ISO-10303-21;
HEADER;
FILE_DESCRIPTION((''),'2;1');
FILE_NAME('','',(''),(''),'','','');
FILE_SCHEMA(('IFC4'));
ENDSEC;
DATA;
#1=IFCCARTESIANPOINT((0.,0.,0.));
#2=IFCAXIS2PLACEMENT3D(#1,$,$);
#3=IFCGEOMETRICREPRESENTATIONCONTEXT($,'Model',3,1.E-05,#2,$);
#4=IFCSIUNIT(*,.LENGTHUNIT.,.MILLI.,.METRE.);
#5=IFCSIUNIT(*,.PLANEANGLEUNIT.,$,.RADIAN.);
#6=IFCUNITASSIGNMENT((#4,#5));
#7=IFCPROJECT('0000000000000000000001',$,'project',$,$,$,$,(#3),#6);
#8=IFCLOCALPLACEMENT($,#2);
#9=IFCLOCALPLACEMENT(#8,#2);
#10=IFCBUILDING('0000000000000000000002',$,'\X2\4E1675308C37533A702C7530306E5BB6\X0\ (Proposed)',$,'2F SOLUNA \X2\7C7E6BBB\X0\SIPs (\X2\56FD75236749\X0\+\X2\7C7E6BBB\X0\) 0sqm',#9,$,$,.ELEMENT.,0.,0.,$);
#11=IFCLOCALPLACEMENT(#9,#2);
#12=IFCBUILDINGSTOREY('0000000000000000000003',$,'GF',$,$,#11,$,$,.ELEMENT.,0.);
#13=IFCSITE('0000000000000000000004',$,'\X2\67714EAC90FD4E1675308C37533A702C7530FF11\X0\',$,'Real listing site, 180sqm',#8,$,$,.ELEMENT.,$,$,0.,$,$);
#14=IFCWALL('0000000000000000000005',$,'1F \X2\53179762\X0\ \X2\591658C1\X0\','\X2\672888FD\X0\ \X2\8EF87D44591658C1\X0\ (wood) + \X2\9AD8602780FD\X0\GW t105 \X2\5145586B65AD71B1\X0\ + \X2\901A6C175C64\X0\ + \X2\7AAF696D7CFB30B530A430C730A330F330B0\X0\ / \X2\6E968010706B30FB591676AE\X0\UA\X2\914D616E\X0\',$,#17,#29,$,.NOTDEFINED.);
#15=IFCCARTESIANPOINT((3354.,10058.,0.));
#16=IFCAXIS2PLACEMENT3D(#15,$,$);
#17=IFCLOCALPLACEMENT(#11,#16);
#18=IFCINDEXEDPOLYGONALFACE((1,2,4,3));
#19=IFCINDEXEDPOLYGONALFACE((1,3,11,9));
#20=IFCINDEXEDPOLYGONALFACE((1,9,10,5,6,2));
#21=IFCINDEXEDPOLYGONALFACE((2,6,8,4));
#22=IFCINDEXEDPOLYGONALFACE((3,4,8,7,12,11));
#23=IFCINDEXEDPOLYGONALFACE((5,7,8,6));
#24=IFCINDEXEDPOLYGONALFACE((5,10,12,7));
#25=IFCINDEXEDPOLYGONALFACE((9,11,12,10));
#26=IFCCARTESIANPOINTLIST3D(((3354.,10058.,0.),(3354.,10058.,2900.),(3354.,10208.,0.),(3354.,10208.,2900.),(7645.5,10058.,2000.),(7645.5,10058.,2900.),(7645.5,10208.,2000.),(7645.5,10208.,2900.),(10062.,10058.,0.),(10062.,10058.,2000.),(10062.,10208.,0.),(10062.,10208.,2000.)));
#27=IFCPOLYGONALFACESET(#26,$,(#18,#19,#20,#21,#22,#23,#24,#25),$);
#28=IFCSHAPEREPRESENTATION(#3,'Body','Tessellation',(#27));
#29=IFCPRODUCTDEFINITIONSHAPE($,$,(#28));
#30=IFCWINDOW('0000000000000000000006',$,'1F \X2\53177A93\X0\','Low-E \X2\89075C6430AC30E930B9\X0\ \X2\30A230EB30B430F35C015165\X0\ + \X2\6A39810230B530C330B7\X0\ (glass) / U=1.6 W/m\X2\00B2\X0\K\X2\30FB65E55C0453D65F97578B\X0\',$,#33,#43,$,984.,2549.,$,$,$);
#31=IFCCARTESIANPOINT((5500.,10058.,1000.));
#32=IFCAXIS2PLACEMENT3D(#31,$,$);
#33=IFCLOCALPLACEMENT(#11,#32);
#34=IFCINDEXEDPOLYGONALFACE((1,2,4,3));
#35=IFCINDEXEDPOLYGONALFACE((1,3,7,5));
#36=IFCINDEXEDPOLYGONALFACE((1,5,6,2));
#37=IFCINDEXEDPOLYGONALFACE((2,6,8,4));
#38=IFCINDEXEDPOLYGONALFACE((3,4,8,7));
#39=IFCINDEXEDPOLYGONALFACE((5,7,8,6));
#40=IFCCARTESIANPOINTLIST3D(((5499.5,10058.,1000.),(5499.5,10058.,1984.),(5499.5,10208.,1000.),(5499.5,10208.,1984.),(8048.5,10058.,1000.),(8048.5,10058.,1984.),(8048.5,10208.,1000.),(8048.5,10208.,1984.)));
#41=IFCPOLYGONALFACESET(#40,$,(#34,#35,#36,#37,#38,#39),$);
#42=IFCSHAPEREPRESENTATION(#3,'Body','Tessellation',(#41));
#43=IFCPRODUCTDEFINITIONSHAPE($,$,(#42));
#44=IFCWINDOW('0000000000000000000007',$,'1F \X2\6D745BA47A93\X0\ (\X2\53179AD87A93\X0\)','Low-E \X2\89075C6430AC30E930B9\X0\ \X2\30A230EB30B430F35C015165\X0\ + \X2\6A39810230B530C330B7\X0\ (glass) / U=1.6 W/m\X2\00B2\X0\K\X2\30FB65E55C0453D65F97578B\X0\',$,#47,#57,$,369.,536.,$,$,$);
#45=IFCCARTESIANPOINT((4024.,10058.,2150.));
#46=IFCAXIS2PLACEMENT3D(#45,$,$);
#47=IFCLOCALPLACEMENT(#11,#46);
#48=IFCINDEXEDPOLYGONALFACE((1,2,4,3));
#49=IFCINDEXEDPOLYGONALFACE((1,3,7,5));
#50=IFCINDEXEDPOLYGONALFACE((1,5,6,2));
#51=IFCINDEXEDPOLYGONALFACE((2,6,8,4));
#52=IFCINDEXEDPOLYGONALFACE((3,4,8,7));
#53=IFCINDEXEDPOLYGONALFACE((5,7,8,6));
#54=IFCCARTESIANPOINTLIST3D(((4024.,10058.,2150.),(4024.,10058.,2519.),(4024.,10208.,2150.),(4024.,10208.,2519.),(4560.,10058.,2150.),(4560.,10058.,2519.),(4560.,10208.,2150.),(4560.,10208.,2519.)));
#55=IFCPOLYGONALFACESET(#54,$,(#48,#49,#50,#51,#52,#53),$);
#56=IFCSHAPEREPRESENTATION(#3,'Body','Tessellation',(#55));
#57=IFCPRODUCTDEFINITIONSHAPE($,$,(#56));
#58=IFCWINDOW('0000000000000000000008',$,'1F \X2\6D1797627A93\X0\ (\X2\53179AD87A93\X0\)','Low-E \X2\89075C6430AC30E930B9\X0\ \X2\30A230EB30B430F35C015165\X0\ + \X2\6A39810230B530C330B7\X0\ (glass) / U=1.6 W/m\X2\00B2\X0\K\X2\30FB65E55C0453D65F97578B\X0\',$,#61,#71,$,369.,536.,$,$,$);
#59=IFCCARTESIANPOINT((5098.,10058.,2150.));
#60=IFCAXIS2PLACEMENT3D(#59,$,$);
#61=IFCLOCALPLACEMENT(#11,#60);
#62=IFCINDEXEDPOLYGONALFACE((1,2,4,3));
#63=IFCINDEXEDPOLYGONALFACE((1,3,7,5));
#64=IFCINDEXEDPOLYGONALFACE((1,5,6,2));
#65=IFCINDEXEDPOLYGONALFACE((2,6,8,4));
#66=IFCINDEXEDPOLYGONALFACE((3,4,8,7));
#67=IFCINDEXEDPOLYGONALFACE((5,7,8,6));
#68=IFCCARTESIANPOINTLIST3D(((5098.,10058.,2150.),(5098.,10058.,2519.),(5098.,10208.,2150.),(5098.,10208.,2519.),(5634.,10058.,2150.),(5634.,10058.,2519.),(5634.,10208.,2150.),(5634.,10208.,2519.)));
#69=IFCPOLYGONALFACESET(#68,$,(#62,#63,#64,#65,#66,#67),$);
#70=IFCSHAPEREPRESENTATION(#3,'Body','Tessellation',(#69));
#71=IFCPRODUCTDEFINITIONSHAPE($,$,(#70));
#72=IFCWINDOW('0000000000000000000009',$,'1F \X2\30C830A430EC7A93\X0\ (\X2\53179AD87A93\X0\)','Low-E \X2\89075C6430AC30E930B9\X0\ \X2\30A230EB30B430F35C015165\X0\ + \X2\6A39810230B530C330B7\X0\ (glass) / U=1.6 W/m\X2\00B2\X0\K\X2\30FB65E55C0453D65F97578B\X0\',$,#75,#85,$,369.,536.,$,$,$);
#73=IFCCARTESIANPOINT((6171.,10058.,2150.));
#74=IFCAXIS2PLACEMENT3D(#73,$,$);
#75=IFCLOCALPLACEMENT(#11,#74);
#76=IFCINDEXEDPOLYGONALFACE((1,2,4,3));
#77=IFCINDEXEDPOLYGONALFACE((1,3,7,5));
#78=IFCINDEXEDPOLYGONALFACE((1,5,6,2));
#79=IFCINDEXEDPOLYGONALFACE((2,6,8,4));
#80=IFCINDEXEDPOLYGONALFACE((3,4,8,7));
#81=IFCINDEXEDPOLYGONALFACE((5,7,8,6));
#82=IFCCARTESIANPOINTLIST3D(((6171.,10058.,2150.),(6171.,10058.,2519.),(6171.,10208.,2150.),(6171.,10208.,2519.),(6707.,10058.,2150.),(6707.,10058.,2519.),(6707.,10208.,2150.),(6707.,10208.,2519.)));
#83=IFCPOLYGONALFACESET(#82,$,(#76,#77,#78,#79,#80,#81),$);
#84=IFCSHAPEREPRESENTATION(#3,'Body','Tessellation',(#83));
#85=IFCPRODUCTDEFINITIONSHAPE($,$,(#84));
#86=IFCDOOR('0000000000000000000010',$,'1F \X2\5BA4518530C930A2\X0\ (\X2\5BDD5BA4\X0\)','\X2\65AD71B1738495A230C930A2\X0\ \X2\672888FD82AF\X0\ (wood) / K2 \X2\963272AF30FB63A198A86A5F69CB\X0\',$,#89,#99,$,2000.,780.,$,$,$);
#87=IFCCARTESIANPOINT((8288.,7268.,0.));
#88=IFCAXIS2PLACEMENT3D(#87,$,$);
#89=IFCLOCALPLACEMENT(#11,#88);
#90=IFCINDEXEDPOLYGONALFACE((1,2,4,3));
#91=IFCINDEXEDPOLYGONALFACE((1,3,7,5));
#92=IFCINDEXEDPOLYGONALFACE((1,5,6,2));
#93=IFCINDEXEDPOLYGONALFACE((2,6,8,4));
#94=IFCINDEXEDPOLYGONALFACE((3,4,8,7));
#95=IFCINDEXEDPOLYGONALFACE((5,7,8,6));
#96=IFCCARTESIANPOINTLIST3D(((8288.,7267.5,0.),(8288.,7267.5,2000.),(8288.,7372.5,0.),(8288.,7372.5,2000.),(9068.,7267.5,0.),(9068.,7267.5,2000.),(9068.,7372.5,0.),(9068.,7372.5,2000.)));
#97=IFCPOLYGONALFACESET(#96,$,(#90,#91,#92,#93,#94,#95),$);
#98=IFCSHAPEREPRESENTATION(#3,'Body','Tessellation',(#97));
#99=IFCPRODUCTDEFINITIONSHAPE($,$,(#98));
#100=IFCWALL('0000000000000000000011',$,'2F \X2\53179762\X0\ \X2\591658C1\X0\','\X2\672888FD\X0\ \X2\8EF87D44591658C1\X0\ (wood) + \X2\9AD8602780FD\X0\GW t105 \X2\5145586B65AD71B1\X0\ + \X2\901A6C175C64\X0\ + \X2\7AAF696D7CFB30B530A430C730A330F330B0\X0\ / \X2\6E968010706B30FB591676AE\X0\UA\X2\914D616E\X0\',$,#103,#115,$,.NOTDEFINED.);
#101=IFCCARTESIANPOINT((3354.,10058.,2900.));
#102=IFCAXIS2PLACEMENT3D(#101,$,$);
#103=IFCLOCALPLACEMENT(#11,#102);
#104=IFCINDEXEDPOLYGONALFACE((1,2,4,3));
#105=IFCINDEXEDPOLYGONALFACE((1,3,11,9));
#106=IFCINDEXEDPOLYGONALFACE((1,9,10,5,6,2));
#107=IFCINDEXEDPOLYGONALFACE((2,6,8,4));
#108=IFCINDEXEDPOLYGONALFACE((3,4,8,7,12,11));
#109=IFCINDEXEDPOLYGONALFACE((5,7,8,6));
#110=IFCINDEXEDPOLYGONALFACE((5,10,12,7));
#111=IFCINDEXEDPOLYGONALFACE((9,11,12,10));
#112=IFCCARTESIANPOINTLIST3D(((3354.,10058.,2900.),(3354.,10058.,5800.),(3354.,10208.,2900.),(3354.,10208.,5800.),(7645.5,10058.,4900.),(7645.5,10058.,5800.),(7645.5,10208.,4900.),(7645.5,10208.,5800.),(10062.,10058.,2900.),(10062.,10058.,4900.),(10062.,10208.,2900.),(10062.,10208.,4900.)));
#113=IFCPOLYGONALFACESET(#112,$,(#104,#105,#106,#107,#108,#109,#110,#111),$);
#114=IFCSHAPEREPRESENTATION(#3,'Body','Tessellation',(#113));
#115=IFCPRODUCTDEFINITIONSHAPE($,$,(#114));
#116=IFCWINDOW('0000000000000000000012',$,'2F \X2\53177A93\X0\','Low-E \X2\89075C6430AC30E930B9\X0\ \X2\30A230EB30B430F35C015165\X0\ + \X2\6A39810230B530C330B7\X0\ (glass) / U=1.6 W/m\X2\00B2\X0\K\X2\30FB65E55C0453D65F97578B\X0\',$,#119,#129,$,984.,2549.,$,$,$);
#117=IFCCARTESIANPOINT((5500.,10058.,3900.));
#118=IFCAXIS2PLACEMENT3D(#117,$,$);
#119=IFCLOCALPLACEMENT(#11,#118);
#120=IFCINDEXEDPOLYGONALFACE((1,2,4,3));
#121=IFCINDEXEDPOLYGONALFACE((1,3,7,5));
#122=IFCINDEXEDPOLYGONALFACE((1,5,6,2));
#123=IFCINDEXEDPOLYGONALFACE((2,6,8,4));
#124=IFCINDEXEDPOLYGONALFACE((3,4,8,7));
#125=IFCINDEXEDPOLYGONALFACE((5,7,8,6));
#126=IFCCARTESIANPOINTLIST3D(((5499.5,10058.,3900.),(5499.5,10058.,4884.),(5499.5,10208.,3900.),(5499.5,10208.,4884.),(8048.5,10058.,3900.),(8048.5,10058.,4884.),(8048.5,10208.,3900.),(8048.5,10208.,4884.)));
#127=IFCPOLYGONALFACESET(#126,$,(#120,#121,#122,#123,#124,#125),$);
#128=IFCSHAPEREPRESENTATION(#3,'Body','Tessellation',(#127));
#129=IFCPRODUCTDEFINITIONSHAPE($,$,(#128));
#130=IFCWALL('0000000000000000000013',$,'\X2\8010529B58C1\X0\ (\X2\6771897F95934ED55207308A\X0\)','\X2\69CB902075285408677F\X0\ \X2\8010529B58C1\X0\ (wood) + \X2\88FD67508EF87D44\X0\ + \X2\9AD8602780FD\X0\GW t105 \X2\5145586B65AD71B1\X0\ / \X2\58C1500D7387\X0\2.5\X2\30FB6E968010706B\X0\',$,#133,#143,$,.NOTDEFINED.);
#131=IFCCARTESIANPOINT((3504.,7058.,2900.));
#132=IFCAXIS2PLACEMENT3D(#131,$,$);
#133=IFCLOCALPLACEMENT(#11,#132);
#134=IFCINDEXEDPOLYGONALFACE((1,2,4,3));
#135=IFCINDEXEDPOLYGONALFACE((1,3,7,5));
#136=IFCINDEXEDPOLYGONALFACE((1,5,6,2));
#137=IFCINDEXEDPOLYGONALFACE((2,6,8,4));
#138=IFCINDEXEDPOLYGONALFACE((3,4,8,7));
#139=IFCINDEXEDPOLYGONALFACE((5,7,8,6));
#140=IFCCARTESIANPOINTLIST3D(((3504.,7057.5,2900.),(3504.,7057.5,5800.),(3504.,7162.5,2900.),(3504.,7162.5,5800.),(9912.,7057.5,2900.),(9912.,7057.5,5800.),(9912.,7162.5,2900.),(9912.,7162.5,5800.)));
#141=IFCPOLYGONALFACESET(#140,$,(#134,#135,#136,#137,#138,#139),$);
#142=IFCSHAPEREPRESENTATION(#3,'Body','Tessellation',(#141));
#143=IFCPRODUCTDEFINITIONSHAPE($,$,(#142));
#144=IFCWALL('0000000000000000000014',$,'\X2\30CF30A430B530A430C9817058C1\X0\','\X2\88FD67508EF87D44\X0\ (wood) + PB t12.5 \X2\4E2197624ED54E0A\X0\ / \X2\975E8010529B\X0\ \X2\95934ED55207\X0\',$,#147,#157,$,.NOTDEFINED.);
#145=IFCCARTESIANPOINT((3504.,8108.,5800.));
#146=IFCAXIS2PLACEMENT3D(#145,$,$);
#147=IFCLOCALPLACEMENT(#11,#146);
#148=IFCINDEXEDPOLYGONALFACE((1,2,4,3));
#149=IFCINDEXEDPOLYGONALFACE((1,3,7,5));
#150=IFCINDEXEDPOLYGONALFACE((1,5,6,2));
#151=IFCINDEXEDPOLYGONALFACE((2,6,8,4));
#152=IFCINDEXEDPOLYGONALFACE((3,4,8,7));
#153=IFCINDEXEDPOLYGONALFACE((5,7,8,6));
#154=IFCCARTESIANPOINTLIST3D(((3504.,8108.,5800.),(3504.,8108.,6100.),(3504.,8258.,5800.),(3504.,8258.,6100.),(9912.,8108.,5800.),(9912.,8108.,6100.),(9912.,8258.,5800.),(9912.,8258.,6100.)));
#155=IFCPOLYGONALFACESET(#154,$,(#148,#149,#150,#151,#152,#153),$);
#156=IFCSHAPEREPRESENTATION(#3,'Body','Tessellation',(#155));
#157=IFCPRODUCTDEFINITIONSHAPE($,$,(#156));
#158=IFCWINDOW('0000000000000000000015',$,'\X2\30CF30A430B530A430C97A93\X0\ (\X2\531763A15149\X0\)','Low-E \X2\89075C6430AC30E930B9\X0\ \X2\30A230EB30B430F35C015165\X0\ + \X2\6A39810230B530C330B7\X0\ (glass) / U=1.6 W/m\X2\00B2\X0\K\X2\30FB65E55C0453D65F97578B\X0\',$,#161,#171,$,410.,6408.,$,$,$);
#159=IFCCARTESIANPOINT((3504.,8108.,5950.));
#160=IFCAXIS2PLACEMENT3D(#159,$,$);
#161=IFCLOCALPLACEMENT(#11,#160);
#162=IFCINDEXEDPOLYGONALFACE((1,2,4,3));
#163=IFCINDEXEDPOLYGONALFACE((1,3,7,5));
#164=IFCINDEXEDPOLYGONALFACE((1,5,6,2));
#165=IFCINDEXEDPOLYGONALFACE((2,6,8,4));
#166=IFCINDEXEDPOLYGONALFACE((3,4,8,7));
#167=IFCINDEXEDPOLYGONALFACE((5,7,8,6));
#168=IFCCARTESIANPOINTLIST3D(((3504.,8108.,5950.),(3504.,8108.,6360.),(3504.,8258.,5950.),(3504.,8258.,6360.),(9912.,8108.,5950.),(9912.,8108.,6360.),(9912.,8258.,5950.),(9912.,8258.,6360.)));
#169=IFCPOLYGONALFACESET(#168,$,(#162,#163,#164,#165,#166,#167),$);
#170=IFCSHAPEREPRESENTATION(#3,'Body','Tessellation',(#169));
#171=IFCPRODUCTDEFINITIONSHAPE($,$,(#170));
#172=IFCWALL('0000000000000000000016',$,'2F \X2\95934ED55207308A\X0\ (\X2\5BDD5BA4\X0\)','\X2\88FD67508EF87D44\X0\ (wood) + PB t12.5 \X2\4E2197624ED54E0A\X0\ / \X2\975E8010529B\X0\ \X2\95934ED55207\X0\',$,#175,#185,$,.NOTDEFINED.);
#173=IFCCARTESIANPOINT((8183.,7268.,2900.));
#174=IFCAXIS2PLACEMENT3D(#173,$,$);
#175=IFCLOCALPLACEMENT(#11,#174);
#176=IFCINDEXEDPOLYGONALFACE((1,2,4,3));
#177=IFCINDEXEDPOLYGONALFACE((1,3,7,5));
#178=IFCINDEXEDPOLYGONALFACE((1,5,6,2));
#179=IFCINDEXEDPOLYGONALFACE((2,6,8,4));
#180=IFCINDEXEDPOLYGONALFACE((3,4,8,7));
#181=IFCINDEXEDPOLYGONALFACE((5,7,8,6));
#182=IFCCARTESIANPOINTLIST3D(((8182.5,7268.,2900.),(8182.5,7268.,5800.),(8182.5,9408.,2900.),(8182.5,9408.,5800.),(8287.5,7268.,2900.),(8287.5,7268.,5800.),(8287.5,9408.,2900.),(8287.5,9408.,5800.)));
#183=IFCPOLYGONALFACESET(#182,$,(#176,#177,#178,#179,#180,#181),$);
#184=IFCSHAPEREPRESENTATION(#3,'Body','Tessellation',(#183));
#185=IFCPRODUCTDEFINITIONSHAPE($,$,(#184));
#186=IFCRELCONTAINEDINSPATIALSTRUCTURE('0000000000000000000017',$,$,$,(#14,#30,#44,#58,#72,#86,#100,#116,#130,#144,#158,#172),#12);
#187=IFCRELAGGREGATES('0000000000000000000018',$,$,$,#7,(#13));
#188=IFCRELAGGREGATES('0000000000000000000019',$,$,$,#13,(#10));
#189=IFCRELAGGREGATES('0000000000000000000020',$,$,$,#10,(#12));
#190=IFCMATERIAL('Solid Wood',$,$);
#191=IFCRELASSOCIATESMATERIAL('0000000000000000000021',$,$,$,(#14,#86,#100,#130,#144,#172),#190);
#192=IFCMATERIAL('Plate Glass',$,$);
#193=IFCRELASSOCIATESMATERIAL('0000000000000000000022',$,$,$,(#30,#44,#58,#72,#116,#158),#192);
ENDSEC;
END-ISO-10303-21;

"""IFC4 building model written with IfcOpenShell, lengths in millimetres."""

from ifc_helpers import new_model, si_unit, frame, frame_2d, origin, place, context, project, spatial, rectangle, extrude, material, element, fill, save


model = new_model("IFC4")

# Units and contexts
model_context = context("Model", 3, precision=1e-05, world=origin())
ifc_project = project(units=[si_unit("LENGTHUNIT", "METRE", prefix="MILLI"), si_unit("PLANEANGLEUNIT", "RADIAN")], contexts=[model_context])

# Site, building, storey
site_placement = place(None, origin())
site = spatial("IfcSite", under=ifc_project, at=site_placement, Name="東京都世田谷区瀬田１", ObjectType="Real listing site, 180sqm", CompositionType="ELEMENT", RefElevation=0.0)
building_placement = place(site_placement, origin())
building = spatial("IfcBuilding", under=site, at=building_placement, Name="世田谷区瀬田の家 (Proposed)", ObjectType="2F SOLUNA 籾殻SIPs (国産杉+籾殻) 0sqm", CompositionType="ELEMENT", ElevationOfRefHeight=0.0, ElevationOfTerrain=0.0)
storey_placement = place(building_placement, origin())
storey = spatial("IfcBuildingStorey", under=building, at=storey_placement, Name="GF", CompositionType="ELEMENT", Elevation=0.0)

# Wall, openings, windows
ifc_material_1 = material(Name="Solid Wood")
wall_1_placement = place(storey_placement, frame((3354.0, 10058.0, 0.0)))
wall_1 = element("IfcWall", 1, at=wall_1_placement, inside=storey, material=ifc_material_1, Name="1F 北面 外壁", Description="木製 軸組外壁 (wood) + 高性能GW t105 充填断熱 + 通気層 + 窯業系サイディング / 準耐火・外皮UA配慮", PredefinedType="NOTDEFINED", context=model_context, shape_type="SweptSolid", body=[
    extrude(rectangle(XDim=6708.0, YDim=150.0, at=frame_2d((3354.0, 75.0))), frame((3354.0, 10058.0, 0.0)), (0.0, 0.0, 1.0), 2900.0),
])
opening_1_placement = place(storey_placement, frame((5500.0, 10058.0, 1000.0)))
opening_1 = element("IfcOpeningElement", 2, at=opening_1_placement, cuts=wall_1, PredefinedType="NOTDEFINED", context=model_context, shape_type="SweptSolid", body=[
    extrude(rectangle(XDim=2549.0, YDim=150.0, at=frame_2d((1274.0, 75.0))), frame((5500.0, 10058.0, 1000.0)), (0.0, 0.0, 1.0), 984.0),
])
opening_2_placement = place(storey_placement, frame((4024.0, 10058.0, 2150.0)))
opening_2 = element("IfcOpeningElement", 3, at=opening_2_placement, cuts=wall_1, PredefinedType="NOTDEFINED", context=model_context, shape_type="SweptSolid", body=[
    extrude(rectangle(XDim=536.0, YDim=150.0, at=frame_2d((268.0, 75.0))), frame((4024.0, 10058.0, 2150.0)), (0.0, 0.0, 1.0), 369.0),
])
opening_3_placement = place(storey_placement, frame((5098.0, 10058.0, 2150.0)))
opening_3 = element("IfcOpeningElement", 4, at=opening_3_placement, cuts=wall_1, PredefinedType="NOTDEFINED", context=model_context, shape_type="SweptSolid", body=[
    extrude(rectangle(XDim=536.0, YDim=150.0, at=frame_2d((268.0, 75.0))), frame((5098.0, 10058.0, 2150.0)), (0.0, 0.0, 1.0), 369.0),
])
opening_4_placement = place(storey_placement, frame((6171.0, 10058.0, 2150.0)))
opening_4 = element("IfcOpeningElement", 5, at=opening_4_placement, cuts=wall_1, PredefinedType="NOTDEFINED", context=model_context, shape_type="SweptSolid", body=[
    extrude(rectangle(XDim=536.0, YDim=150.0, at=frame_2d((268.0, 75.0))), frame((6171.0, 10058.0, 2150.0)), (0.0, 0.0, 1.0), 369.0),
])
ifc_material_2 = material(Name="Plate Glass")
window_1_placement = place(storey_placement, frame((5500.0, 10058.0, 1000.0)))
window_1 = element("IfcWindow", 6, at=window_1_placement, inside=storey, material=ifc_material_2, Name="1F 北窓", Description="Low-E 複層ガラス アルゴン封入 + 樹脂サッシ (glass) / U=1.6 W/m²K・日射取得型", OverallHeight=984.0, OverallWidth=2549.0, context=model_context, shape_type="SweptSolid", body=[
    extrude(rectangle(XDim=2549.0, YDim=150.0, at=frame_2d((1274.0, 75.0))), frame((5500.0, 10058.0, 1000.0)), (0.0, 0.0, 1.0), 984.0),
])
fill(opening_1, window_1)
window_2_placement = place(storey_placement, frame((4024.0, 10058.0, 2150.0)))
window_2 = element("IfcWindow", 7, at=window_2_placement, inside=storey, material=ifc_material_2, Name="1F 浴室窓 (北高窓)", Description="Low-E 複層ガラス アルゴン封入 + 樹脂サッシ (glass) / U=1.6 W/m²K・日射取得型", OverallHeight=369.0, OverallWidth=536.0, context=model_context, shape_type="SweptSolid", body=[
    extrude(rectangle(XDim=536.0, YDim=150.0, at=frame_2d((268.0, 75.0))), frame((4024.0, 10058.0, 2150.0)), (0.0, 0.0, 1.0), 369.0),
])
fill(opening_2, window_2)
window_3_placement = place(storey_placement, frame((5098.0, 10058.0, 2150.0)))
window_3 = element("IfcWindow", 8, at=window_3_placement, inside=storey, material=ifc_material_2, Name="1F 洗面窓 (北高窓)", Description="Low-E 複層ガラス アルゴン封入 + 樹脂サッシ (glass) / U=1.6 W/m²K・日射取得型", OverallHeight=369.0, OverallWidth=536.0, context=model_context, shape_type="SweptSolid", body=[
    extrude(rectangle(XDim=536.0, YDim=150.0, at=frame_2d((268.0, 75.0))), frame((5098.0, 10058.0, 2150.0)), (0.0, 0.0, 1.0), 369.0),
])
fill(opening_3, window_3)
window_4_placement = place(storey_placement, frame((6171.0, 10058.0, 2150.0)))
window_4 = element("IfcWindow", 9, at=window_4_placement, inside=storey, material=ifc_material_2, Name="1F トイレ窓 (北高窓)", Description="Low-E 複層ガラス アルゴン封入 + 樹脂サッシ (glass) / U=1.6 W/m²K・日射取得型", OverallHeight=369.0, OverallWidth=536.0, context=model_context, shape_type="SweptSolid", body=[
    extrude(rectangle(XDim=536.0, YDim=150.0, at=frame_2d((268.0, 75.0))), frame((6171.0, 10058.0, 2150.0)), (0.0, 0.0, 1.0), 369.0),
])
fill(opening_4, window_4)

# Door
door_1_placement = place(storey_placement, frame((8288.0, 7268.0, 0.0)))
element("IfcDoor", 10, at=door_1_placement, inside=storey, material=ifc_material_1, Name="1F 室内ドア (寝室)", Description="断熱玄関ドア 木製芯 (wood) / K2 防犯・採風機構", OverallHeight=2000.0, OverallWidth=780.0, context=model_context, shape_type="SweptSolid", body=[
    extrude(rectangle(XDim=780.0, YDim=105.0, at=frame_2d((390.0, 52.0))), frame((8288.0, 7268.0, 0.0)), (0.0, 0.0, 1.0), 2000.0),
])

# Wall, opening, window
wall_2_placement = place(storey_placement, frame((3354.0, 10058.0, 2900.0)))
wall_2 = element("IfcWall", 11, at=wall_2_placement, inside=storey, material=ifc_material_1, Name="2F 北面 外壁", Description="木製 軸組外壁 (wood) + 高性能GW t105 充填断熱 + 通気層 + 窯業系サイディング / 準耐火・外皮UA配慮", PredefinedType="NOTDEFINED", context=model_context, shape_type="SweptSolid", body=[
    extrude(rectangle(XDim=6708.0, YDim=150.0, at=frame_2d((3354.0, 75.0))), frame((3354.0, 10058.0, 2900.0)), (0.0, 0.0, 1.0), 2900.0),
])
opening_5_placement = place(storey_placement, frame((5500.0, 10058.0, 3900.0)))
opening_5 = element("IfcOpeningElement", 12, at=opening_5_placement, cuts=wall_2, PredefinedType="NOTDEFINED", context=model_context, shape_type="SweptSolid", body=[
    extrude(rectangle(XDim=2549.0, YDim=150.0, at=frame_2d((1274.0, 75.0))), frame((5500.0, 10058.0, 3900.0)), (0.0, 0.0, 1.0), 984.0),
])
window_5_placement = place(storey_placement, frame((5500.0, 10058.0, 3900.0)))
window_5 = element("IfcWindow", 13, at=window_5_placement, inside=storey, material=ifc_material_2, Name="2F 北窓", Description="Low-E 複層ガラス アルゴン封入 + 樹脂サッシ (glass) / U=1.6 W/m²K・日射取得型", OverallHeight=984.0, OverallWidth=2549.0, context=model_context, shape_type="SweptSolid", body=[
    extrude(rectangle(XDim=2549.0, YDim=150.0, at=frame_2d((1274.0, 75.0))), frame((5500.0, 10058.0, 3900.0)), (0.0, 0.0, 1.0), 984.0),
])
fill(opening_5, window_5)

# Wall
wall_3_placement = place(storey_placement, frame((3504.0, 7058.0, 2900.0)))
element("IfcWall", 14, at=wall_3_placement, inside=storey, material=ifc_material_1, Name="耐力壁 (東西間仕切り)", Description="構造用合板 耐力壁 (wood) + 製材軸組 + 高性能GW t105 充填断熱 / 壁倍率2.5・準耐火", PredefinedType="NOTDEFINED", context=model_context, shape_type="SweptSolid", body=[
    extrude(rectangle(XDim=6408.0, YDim=105.0, at=frame_2d((3204.0, 52.0))), frame((3504.0, 7058.0, 2900.0)), (0.0, 0.0, 1.0), 2900.0),
])

# Wall, opening, window
wall_4_placement = place(storey_placement, frame((3504.0, 8108.0, 5800.0)))
wall_4 = element("IfcWall", 15, at=wall_4_placement, inside=storey, material=ifc_material_1, Name="ハイサイド腰壁", Description="製材軸組 (wood) + PB t12.5 両面仕上 / 非耐力 間仕切", PredefinedType="NOTDEFINED", context=model_context, shape_type="SweptSolid", body=[
    extrude(rectangle(XDim=6408.0, YDim=150.0, at=frame_2d((3204.0, 75.0))), frame((3504.0, 8108.0, 5800.0)), (0.0, 0.0, 1.0), 700.0),
])
opening_6_placement = place(storey_placement, frame((3504.0, 8108.0, 5950.0)))
opening_6 = element("IfcOpeningElement", 16, at=opening_6_placement, cuts=wall_4, PredefinedType="NOTDEFINED", context=model_context, shape_type="SweptSolid", body=[
    extrude(rectangle(XDim=6408.0, YDim=150.0, at=frame_2d((3204.0, 75.0))), frame((3504.0, 8108.0, 5950.0)), (0.0, 0.0, 1.0), 410.0),
])
window_6_placement = place(storey_placement, frame((3504.0, 8108.0, 5950.0)))
window_6 = element("IfcWindow", 17, at=window_6_placement, inside=storey, material=ifc_material_2, Name="ハイサイド窓 (北採光)", Description="Low-E 複層ガラス アルゴン封入 + 樹脂サッシ (glass) / U=1.6 W/m²K・日射取得型", OverallHeight=410.0, OverallWidth=6408.0, context=model_context, shape_type="SweptSolid", body=[
    extrude(rectangle(XDim=6408.0, YDim=150.0, at=frame_2d((3204.0, 75.0))), frame((3504.0, 8108.0, 5950.0)), (0.0, 0.0, 1.0), 410.0),
])
fill(opening_6, window_6)

# Wall
wall_5_placement = place(storey_placement, frame((8183.0, 7268.0, 2900.0)))
element("IfcWall", 18, at=wall_5_placement, inside=storey, material=ifc_material_1, Name="2F 間仕切り (寝室)", Description="製材軸組 (wood) + PB t12.5 両面仕上 / 非耐力 間仕切", PredefinedType="NOTDEFINED", context=model_context, shape_type="SweptSolid", body=[
    extrude(rectangle(XDim=105.0, YDim=2140.0, at=frame_2d((52.0, 1070.0))), frame((8183.0, 7268.0, 2900.0)), (0.0, 0.0, 1.0), 2900.0),
])

save(model, "model.ifc")
